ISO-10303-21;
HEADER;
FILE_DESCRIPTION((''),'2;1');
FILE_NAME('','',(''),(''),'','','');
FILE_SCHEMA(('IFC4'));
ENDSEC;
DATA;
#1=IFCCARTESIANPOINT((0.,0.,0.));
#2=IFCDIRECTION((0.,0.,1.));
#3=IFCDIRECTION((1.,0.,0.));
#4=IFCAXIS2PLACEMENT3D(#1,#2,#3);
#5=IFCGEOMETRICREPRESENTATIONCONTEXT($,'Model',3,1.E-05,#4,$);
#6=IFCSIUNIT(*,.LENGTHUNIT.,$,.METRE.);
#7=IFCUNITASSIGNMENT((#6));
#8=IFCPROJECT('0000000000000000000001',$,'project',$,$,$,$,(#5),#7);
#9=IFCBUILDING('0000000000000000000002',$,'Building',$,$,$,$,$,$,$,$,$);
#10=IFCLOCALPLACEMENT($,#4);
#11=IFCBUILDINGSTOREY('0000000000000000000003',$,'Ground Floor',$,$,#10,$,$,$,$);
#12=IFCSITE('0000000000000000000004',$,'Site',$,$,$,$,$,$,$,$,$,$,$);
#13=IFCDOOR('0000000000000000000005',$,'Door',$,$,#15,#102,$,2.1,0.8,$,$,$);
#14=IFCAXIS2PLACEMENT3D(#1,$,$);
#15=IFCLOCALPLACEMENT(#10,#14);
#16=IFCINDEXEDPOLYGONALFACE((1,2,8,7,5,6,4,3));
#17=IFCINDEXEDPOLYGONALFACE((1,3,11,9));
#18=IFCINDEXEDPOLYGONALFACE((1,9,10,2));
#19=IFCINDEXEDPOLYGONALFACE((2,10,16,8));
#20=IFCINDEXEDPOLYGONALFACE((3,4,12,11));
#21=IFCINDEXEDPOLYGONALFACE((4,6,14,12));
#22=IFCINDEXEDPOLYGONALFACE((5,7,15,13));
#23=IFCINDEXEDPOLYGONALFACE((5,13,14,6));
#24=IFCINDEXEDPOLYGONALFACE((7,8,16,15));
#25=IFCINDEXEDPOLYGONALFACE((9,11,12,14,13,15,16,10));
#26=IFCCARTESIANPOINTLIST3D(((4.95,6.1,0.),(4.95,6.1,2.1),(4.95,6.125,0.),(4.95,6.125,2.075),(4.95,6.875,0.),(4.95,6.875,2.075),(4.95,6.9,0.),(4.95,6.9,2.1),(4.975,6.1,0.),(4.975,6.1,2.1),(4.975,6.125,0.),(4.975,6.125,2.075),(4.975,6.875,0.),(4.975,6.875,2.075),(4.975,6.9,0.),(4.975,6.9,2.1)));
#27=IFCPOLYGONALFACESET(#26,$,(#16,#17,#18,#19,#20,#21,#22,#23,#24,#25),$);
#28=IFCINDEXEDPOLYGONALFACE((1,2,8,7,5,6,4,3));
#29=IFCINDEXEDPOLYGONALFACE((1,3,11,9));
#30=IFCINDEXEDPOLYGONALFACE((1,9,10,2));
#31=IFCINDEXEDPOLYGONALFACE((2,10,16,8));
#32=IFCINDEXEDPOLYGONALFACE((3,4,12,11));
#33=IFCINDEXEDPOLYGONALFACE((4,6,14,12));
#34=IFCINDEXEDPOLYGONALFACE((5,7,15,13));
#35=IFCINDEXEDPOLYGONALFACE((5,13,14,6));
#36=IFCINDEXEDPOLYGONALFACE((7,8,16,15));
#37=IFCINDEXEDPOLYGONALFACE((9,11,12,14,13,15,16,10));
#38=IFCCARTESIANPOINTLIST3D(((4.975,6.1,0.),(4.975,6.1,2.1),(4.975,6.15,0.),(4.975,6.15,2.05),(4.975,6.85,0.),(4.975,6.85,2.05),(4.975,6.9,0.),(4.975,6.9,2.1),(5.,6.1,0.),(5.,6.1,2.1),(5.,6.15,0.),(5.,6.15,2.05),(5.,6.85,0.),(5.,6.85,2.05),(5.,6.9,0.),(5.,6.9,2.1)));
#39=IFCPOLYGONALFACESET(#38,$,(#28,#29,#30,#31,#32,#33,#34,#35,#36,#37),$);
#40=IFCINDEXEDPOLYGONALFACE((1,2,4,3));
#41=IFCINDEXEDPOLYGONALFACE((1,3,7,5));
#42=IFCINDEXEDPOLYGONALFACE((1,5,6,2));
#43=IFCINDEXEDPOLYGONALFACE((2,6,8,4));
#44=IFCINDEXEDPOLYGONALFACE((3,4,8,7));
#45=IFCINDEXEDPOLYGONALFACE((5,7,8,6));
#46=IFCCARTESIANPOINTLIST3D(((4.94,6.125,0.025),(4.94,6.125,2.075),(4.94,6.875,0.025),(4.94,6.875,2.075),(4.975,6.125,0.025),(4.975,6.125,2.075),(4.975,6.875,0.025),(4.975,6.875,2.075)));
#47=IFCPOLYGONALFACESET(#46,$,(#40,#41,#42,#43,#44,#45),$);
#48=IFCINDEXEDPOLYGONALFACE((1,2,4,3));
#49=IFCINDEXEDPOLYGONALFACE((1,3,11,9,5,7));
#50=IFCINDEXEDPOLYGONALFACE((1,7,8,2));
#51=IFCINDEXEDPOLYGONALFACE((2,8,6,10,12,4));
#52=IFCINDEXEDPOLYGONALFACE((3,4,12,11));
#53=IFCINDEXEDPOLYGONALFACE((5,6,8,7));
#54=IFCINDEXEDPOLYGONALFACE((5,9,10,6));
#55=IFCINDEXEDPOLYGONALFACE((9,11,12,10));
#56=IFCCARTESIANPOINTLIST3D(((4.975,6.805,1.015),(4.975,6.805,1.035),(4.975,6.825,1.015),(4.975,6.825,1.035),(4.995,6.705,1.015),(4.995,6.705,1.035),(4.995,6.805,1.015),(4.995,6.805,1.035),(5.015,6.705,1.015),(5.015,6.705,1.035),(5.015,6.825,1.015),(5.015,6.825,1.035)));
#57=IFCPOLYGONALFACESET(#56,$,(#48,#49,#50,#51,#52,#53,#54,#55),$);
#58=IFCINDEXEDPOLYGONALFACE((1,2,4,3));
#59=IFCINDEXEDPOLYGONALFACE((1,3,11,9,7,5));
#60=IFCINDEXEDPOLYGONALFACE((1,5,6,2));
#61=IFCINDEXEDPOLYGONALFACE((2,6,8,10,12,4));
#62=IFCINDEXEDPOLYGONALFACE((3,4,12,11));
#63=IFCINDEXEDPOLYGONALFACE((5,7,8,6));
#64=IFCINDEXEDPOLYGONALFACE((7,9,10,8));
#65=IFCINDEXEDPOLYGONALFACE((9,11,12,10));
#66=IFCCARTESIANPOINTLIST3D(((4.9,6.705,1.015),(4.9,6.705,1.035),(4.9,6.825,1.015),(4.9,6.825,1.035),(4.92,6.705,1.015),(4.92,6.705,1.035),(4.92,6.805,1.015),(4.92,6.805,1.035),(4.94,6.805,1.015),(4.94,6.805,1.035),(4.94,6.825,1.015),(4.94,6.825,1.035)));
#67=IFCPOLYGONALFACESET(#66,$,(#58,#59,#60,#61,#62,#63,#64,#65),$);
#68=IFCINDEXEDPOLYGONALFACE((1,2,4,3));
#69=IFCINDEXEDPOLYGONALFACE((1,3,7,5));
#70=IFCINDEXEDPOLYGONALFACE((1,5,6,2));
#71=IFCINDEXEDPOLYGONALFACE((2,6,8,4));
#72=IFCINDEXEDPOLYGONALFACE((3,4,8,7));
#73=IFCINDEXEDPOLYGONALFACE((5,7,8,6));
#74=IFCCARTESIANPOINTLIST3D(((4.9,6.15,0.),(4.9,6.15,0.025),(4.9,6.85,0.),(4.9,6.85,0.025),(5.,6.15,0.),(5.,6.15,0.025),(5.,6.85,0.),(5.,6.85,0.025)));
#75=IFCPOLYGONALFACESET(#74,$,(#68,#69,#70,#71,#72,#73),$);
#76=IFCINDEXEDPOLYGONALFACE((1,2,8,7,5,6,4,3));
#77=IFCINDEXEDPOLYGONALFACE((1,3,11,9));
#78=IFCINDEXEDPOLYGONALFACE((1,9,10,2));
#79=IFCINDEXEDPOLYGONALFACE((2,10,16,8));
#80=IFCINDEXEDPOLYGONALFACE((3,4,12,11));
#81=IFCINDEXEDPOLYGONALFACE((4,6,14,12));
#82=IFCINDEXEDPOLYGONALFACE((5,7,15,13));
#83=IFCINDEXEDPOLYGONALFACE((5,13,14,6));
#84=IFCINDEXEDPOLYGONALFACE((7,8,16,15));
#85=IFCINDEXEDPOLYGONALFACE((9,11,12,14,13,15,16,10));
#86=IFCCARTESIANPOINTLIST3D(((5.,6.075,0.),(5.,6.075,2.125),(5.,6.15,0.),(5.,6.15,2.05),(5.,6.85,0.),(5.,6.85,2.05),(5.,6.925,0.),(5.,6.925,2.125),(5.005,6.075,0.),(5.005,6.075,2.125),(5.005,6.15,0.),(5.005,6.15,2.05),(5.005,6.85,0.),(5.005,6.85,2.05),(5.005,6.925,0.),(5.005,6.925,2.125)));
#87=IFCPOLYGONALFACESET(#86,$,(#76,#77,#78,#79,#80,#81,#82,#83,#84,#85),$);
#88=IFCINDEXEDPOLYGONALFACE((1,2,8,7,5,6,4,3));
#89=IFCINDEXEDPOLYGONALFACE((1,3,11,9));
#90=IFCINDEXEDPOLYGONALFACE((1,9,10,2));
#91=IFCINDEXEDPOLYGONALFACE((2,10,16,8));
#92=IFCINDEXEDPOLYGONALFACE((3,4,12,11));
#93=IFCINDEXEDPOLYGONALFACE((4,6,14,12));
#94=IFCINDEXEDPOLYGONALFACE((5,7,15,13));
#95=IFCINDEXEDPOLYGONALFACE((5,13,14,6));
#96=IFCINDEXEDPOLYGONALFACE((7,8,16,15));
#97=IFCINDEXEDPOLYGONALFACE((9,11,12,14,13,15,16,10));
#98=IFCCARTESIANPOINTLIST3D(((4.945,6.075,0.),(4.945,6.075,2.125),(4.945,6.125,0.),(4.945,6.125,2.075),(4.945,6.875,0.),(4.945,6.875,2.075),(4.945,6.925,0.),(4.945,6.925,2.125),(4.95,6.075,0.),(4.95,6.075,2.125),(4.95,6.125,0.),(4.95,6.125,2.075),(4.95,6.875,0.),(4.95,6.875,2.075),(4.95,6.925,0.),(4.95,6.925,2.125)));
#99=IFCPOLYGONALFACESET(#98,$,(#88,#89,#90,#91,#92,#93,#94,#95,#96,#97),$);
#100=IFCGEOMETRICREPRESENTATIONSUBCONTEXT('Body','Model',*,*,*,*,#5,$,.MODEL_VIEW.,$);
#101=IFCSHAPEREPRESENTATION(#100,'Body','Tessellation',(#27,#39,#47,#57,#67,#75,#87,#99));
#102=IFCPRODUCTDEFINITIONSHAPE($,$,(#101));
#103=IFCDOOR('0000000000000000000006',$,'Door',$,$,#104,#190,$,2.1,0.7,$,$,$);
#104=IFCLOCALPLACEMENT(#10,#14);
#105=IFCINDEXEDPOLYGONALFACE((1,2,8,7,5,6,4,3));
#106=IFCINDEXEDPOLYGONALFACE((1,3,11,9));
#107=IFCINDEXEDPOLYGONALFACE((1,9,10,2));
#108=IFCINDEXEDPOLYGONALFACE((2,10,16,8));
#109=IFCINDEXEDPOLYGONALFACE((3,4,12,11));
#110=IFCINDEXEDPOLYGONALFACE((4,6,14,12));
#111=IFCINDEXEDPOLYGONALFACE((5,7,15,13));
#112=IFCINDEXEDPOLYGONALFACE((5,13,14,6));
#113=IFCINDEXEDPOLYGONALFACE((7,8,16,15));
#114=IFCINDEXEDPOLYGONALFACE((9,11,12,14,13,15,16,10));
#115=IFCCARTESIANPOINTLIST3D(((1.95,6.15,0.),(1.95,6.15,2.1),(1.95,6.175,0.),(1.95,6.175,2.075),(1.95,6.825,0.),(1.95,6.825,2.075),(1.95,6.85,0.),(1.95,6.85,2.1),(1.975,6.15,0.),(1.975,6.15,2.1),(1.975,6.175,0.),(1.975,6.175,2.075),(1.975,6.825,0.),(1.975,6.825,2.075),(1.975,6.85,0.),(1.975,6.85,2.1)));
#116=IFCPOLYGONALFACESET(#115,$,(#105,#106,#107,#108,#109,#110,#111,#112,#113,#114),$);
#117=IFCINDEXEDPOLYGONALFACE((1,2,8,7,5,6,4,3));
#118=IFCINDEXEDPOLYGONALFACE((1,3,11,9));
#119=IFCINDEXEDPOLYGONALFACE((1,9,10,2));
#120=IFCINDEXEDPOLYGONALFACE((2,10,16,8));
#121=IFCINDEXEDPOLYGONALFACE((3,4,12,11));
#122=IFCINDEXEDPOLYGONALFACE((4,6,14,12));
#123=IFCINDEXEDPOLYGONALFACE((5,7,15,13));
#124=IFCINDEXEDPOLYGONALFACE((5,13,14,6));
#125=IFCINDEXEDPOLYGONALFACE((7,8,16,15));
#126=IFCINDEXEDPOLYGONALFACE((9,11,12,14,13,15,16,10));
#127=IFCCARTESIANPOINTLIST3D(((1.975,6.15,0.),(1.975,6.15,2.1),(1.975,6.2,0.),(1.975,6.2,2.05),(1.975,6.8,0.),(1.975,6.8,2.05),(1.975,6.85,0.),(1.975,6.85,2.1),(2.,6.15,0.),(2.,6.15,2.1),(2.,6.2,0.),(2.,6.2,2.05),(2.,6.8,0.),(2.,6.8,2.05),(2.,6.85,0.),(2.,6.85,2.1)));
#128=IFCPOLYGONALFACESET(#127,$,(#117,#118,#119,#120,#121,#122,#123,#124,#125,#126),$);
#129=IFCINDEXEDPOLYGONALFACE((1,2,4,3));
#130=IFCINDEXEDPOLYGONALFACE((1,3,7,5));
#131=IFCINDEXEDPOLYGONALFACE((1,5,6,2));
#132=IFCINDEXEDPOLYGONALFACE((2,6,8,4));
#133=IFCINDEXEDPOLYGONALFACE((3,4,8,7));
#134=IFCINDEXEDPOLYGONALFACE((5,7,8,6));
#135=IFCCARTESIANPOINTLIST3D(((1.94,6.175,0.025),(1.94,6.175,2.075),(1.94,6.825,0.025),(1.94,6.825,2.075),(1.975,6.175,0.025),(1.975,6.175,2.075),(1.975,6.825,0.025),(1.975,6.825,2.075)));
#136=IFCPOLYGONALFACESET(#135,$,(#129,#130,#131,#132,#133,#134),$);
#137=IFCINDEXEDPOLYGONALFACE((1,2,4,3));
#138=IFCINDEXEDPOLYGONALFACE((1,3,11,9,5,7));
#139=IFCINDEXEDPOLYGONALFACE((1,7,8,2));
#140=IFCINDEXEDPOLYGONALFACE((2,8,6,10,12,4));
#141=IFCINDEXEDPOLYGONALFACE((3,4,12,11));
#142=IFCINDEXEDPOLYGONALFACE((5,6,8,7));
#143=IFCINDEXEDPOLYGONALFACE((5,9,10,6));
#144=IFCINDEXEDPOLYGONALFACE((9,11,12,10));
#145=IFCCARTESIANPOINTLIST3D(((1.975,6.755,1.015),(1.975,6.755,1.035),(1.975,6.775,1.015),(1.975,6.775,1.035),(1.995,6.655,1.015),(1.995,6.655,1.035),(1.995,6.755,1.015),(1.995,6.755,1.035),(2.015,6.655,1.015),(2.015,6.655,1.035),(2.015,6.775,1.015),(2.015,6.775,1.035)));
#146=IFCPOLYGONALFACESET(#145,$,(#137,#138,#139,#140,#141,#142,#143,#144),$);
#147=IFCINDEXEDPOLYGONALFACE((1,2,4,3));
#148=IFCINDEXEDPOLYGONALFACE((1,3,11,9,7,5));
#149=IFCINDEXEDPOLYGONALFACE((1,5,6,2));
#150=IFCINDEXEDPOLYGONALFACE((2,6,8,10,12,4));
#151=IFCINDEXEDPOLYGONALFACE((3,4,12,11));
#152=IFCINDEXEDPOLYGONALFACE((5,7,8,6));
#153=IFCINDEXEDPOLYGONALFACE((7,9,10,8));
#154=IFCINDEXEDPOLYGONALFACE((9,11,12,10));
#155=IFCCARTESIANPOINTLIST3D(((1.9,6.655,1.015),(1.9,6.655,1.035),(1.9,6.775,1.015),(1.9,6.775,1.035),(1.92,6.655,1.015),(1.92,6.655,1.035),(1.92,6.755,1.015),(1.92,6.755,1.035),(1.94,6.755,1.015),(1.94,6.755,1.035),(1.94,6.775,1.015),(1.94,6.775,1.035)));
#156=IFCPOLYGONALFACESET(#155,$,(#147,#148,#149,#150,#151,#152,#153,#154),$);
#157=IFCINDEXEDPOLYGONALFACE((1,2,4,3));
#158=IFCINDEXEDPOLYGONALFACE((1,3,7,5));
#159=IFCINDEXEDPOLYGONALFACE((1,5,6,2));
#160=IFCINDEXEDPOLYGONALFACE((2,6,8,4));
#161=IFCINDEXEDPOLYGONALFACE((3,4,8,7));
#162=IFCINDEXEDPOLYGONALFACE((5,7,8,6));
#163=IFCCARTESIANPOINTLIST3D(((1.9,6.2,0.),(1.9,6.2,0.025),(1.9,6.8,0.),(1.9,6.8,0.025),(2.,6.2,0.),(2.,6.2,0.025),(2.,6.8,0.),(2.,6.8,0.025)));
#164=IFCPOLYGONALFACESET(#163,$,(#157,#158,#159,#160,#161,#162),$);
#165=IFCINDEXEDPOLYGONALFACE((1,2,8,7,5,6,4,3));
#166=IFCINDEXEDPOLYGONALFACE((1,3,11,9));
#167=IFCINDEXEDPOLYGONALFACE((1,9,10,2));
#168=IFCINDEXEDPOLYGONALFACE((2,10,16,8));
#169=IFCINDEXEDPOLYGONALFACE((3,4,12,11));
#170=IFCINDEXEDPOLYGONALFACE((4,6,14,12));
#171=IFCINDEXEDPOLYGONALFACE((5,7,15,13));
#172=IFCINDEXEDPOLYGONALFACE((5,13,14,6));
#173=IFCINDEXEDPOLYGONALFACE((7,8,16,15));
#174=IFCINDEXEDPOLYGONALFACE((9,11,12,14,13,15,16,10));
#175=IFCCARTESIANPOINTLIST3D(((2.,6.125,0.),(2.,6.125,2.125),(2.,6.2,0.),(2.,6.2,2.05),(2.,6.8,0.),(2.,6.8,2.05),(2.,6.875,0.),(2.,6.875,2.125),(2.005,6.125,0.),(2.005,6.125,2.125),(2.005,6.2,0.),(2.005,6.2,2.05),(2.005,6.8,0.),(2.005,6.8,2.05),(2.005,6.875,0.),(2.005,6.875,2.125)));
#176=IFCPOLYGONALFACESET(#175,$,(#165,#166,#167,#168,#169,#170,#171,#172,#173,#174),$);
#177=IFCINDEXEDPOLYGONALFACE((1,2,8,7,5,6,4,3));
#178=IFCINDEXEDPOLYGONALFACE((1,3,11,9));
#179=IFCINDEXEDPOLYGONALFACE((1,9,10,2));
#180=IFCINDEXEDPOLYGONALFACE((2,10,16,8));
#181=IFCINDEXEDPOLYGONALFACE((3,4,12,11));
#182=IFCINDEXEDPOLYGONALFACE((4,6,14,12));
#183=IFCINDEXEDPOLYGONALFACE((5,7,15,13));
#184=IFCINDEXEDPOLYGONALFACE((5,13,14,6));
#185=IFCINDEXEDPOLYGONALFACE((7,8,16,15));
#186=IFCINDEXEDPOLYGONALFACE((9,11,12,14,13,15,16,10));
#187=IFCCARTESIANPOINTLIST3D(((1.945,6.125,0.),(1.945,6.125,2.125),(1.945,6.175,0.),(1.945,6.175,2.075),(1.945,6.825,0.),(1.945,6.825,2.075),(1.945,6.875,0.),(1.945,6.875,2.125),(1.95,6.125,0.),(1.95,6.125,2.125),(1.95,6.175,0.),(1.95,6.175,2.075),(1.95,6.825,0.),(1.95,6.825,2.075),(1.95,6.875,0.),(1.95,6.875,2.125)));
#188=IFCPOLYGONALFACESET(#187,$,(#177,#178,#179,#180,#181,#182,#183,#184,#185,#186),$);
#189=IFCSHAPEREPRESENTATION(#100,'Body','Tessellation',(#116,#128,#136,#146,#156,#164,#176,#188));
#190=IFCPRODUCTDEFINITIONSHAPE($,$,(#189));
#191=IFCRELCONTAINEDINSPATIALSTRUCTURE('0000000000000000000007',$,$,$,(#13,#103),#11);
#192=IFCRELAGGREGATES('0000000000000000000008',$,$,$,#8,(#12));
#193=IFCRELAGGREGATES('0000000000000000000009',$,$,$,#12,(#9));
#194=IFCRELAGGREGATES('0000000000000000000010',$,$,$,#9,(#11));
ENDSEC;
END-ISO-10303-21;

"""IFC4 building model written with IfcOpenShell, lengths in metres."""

from ifc_helpers import new_model, si_unit, frame, origin_with_axes, place, context, subcontext, project, spatial, line, indexed_curve, outline, extrude, element, save


model = new_model("IFC4")

# Units and contexts
model_context = context("Model", 3, precision=1e-05, world=origin_with_axes())
body_context = subcontext(model_context, "Body", "Model", "MODEL_VIEW")
ifc_project = project(units=[si_unit("LENGTHUNIT", "METRE")], contexts=[model_context])

# Site, building, storey
site = spatial("IfcSite", under=ifc_project, Name="Site")
building = spatial("IfcBuilding", under=site, Name="Building")
storey_placement = place(None, origin_with_axes())
storey = spatial("IfcBuildingStorey", under=building, at=storey_placement, Name="Ground Floor")

# Doors
door_1_placement = place(storey_placement, frame((5.0, 6.1, 0.0), z_axis=(0.0, 0.0, 1.0), x_axis=(0.0, 1.0, 0.0)))
element("IfcDoor", 1, at=door_1_placement, inside=storey, Name="Door", OverallHeight=2.1, OverallWidth=0.8, context=body_context, shape_type="SweptSolid", body=[
    extrude(outline(indexed_curve([(0.0, 0.0), (0.0, 2.1), (0.8, 2.1), (0.8, 0.0), (0.775, 0.0), (0.775, 2.075), (0.025, 2.075), (0.025, 0.0)], segments=[line(1, 2, 3, 4, 5, 6, 7, 8, 1)])), frame((0.0, 0.025, 0.0), z_axis=(0.0, -1.0, 0.0), x_axis=(1.0, 0.0, 0.0)), (0.0, 0.0, -1.0), 0.025),
    extrude(outline(indexed_curve([(0.0, 0.0), (0.0, 2.1), (0.8, 2.1), (0.8, 0.0), (0.75, 0.0), (0.75, 2.05), (0.05, 2.05), (0.05, 0.0)], segments=[line(1, 2, 3, 4, 5, 6, 7, 8, 1)])), frame((0.0, 0.0, 0.0), z_axis=(0.0, -1.0, 0.0), x_axis=(1.0, 0.0, 0.0)), (0.0, 0.0, -1.0), 0.025),
    extrude(outline(indexed_curve([(0.0, 0.0), (0.75, 0.0), (0.75, 0.035), (0.0, 0.035)], segments=[line(1, 2, 3, 4, 1)])), frame((0.025, 0.025, 0.025), z_axis=(0.0, 0.0, 1.0), x_axis=(1.0, 0.0, 0.0)), (0.0, 0.0, 1.0), 2.05),
    extrude(outline(indexed_curve([(0.0, 0.0), (0.0, -0.04), (-0.12, -0.04), (-0.12, -0.02), (-0.02, -0.02), (-0.02, 0.0)], segments=[line(1, 2, 3, 4, 5, 6, 1)])), frame((0.725, 0.025, 1.015), z_axis=(0.0, 0.0, 1.0), x_axis=(1.0, 0.0, 0.0)), (0.0, 0.0, 1.0), 0.02),
    extrude(outline(indexed_curve([(0.0, 0.0), (0.0, 0.04), (-0.12, 0.04), (-0.12, 0.02), (-0.02, 0.02), (-0.02, 0.0)], segments=[line(1, 2, 3, 4, 5, 6, 1)])), frame((0.725, 0.06, 1.015), z_axis=(0.0, 0.0, 1.0), x_axis=(1.0, 0.0, 0.0)), (0.0, 0.0, 1.0), 0.02),
    extrude(outline(indexed_curve([(0.0, 0.0), (0.7, 0.0), (0.7, 0.1), (0.0, 0.1)], segments=[line(1, 2, 3, 4, 1)])), frame((0.05, 0.0, 0.0), z_axis=(0.0, 0.0, 1.0), x_axis=(1.0, 0.0, 0.0)), (0.0, 0.0, 1.0), 0.025),
    extrude(outline(indexed_curve([(0.0, 0.0), (0.0, 2.125), (0.85, 2.125), (0.85, 0.0), (0.775, 0.0), (0.775, 2.05), (0.075, 2.05), (0.075, 0.0)], segments=[line(1, 2, 3, 4, 5, 6, 7, 8, 1)])), frame((-0.025, -0.005, 0.0), z_axis=(0.0, -1.0, 0.0), x_axis=(1.0, 0.0, 0.0)), (0.0, 0.0, -1.0), 0.005),
    extrude(outline(indexed_curve([(0.0, 0.0), (0.0, 2.125), (0.85, 2.125), (0.85, 0.0), (0.8, 0.0), (0.8, 2.075), (0.05, 2.075), (0.05, 0.0)], segments=[line(1, 2, 3, 4, 5, 6, 7, 8, 1)])), frame((-0.025, 0.05, 0.0), z_axis=(0.0, -1.0, 0.0), x_axis=(1.0, 0.0, 0.0)), (0.0, 0.0, -1.0), 0.005),
])
door_2_placement = place(storey_placement, frame((2.0, 6.15, 0.0), z_axis=(0.0, 0.0, 1.0), x_axis=(0.0, 1.0, 0.0)))
element("IfcDoor", 2, at=door_2_placement, inside=storey, Name="Door", OverallHeight=2.1, OverallWidth=0.7, context=body_context, shape_type="SweptSolid", body=[
    extrude(outline(indexed_curve([(0.0, 0.0), (0.0, 2.1), (0.7, 2.1), (0.7, 0.0), (0.675, 0.0), (0.675, 2.075), (0.025, 2.075), (0.025, 0.0)], segments=[line(1, 2, 3, 4, 5, 6, 7, 8, 1)])), frame((0.0, 0.025, 0.0), z_axis=(0.0, -1.0, 0.0), x_axis=(1.0, 0.0, 0.0)), (0.0, 0.0, -1.0), 0.025),
    extrude(outline(indexed_curve([(0.0, 0.0), (0.0, 2.1), (0.7, 2.1), (0.7, 0.0), (0.65, 0.0), (0.65, 2.05), (0.05, 2.05), (0.05, 0.0)], segments=[line(1, 2, 3, 4, 5, 6, 7, 8, 1)])), frame((0.0, 0.0, 0.0), z_axis=(0.0, -1.0, 0.0), x_axis=(1.0, 0.0, 0.0)), (0.0, 0.0, -1.0), 0.025),
    extrude(outline(indexed_curve([(0.0, 0.0), (0.65, 0.0), (0.65, 0.035), (0.0, 0.035)], segments=[line(1, 2, 3, 4, 1)])), frame((0.025, 0.025, 0.025), z_axis=(0.0, 0.0, 1.0), x_axis=(1.0, 0.0, 0.0)), (0.0, 0.0, 1.0), 2.05),
    extrude(outline(indexed_curve([(0.0, 0.0), (0.0, -0.04), (-0.12, -0.04), (-0.12, -0.02), (-0.02, -0.02), (-0.02, 0.0)], segments=[line(1, 2, 3, 4, 5, 6, 1)])), frame((0.625, 0.025, 1.015), z_axis=(0.0, 0.0, 1.0), x_axis=(1.0, 0.0, 0.0)), (0.0, 0.0, 1.0), 0.02),
    extrude(outline(indexed_curve([(0.0, 0.0), (0.0, 0.04), (-0.12, 0.04), (-0.12, 0.02), (-0.02, 0.02), (-0.02, 0.0)], segments=[line(1, 2, 3, 4, 5, 6, 1)])), frame((0.625, 0.06, 1.015), z_axis=(0.0, 0.0, 1.0), x_axis=(1.0, 0.0, 0.0)), (0.0, 0.0, 1.0), 0.02),
    extrude(outline(indexed_curve([(0.0, 0.0), (0.6, 0.0), (0.6, 0.1), (0.0, 0.1)], segments=[line(1, 2, 3, 4, 1)])), frame((0.05, 0.0, 0.0), z_axis=(0.0, 0.0, 1.0), x_axis=(1.0, 0.0, 0.0)), (0.0, 0.0, 1.0), 0.025),
    extrude(outline(indexed_curve([(0.0, 0.0), (0.0, 2.125), (0.75, 2.125), (0.75, 0.0), (0.675, 0.0), (0.675, 2.05), (0.075, 2.05), (0.075, 0.0)], segments=[line(1, 2, 3, 4, 5, 6, 7, 8, 1)])), frame((-0.025, -0.005, 0.0), z_axis=(0.0, -1.0, 0.0), x_axis=(1.0, 0.0, 0.0)), (0.0, 0.0, -1.0), 0.005),
    extrude(outline(indexed_curve([(0.0, 0.0), (0.0, 2.125), (0.75, 2.125), (0.75, 0.0), (0.7, 0.0), (0.7, 2.075), (0.05, 2.075), (0.05, 0.0)], segments=[line(1, 2, 3, 4, 5, 6, 7, 8, 1)])), frame((-0.025, 0.05, 0.0), z_axis=(0.0, -1.0, 0.0), x_axis=(1.0, 0.0, 0.0)), (0.0, 0.0, -1.0), 0.005),
])

save(model, "model.ifc")
